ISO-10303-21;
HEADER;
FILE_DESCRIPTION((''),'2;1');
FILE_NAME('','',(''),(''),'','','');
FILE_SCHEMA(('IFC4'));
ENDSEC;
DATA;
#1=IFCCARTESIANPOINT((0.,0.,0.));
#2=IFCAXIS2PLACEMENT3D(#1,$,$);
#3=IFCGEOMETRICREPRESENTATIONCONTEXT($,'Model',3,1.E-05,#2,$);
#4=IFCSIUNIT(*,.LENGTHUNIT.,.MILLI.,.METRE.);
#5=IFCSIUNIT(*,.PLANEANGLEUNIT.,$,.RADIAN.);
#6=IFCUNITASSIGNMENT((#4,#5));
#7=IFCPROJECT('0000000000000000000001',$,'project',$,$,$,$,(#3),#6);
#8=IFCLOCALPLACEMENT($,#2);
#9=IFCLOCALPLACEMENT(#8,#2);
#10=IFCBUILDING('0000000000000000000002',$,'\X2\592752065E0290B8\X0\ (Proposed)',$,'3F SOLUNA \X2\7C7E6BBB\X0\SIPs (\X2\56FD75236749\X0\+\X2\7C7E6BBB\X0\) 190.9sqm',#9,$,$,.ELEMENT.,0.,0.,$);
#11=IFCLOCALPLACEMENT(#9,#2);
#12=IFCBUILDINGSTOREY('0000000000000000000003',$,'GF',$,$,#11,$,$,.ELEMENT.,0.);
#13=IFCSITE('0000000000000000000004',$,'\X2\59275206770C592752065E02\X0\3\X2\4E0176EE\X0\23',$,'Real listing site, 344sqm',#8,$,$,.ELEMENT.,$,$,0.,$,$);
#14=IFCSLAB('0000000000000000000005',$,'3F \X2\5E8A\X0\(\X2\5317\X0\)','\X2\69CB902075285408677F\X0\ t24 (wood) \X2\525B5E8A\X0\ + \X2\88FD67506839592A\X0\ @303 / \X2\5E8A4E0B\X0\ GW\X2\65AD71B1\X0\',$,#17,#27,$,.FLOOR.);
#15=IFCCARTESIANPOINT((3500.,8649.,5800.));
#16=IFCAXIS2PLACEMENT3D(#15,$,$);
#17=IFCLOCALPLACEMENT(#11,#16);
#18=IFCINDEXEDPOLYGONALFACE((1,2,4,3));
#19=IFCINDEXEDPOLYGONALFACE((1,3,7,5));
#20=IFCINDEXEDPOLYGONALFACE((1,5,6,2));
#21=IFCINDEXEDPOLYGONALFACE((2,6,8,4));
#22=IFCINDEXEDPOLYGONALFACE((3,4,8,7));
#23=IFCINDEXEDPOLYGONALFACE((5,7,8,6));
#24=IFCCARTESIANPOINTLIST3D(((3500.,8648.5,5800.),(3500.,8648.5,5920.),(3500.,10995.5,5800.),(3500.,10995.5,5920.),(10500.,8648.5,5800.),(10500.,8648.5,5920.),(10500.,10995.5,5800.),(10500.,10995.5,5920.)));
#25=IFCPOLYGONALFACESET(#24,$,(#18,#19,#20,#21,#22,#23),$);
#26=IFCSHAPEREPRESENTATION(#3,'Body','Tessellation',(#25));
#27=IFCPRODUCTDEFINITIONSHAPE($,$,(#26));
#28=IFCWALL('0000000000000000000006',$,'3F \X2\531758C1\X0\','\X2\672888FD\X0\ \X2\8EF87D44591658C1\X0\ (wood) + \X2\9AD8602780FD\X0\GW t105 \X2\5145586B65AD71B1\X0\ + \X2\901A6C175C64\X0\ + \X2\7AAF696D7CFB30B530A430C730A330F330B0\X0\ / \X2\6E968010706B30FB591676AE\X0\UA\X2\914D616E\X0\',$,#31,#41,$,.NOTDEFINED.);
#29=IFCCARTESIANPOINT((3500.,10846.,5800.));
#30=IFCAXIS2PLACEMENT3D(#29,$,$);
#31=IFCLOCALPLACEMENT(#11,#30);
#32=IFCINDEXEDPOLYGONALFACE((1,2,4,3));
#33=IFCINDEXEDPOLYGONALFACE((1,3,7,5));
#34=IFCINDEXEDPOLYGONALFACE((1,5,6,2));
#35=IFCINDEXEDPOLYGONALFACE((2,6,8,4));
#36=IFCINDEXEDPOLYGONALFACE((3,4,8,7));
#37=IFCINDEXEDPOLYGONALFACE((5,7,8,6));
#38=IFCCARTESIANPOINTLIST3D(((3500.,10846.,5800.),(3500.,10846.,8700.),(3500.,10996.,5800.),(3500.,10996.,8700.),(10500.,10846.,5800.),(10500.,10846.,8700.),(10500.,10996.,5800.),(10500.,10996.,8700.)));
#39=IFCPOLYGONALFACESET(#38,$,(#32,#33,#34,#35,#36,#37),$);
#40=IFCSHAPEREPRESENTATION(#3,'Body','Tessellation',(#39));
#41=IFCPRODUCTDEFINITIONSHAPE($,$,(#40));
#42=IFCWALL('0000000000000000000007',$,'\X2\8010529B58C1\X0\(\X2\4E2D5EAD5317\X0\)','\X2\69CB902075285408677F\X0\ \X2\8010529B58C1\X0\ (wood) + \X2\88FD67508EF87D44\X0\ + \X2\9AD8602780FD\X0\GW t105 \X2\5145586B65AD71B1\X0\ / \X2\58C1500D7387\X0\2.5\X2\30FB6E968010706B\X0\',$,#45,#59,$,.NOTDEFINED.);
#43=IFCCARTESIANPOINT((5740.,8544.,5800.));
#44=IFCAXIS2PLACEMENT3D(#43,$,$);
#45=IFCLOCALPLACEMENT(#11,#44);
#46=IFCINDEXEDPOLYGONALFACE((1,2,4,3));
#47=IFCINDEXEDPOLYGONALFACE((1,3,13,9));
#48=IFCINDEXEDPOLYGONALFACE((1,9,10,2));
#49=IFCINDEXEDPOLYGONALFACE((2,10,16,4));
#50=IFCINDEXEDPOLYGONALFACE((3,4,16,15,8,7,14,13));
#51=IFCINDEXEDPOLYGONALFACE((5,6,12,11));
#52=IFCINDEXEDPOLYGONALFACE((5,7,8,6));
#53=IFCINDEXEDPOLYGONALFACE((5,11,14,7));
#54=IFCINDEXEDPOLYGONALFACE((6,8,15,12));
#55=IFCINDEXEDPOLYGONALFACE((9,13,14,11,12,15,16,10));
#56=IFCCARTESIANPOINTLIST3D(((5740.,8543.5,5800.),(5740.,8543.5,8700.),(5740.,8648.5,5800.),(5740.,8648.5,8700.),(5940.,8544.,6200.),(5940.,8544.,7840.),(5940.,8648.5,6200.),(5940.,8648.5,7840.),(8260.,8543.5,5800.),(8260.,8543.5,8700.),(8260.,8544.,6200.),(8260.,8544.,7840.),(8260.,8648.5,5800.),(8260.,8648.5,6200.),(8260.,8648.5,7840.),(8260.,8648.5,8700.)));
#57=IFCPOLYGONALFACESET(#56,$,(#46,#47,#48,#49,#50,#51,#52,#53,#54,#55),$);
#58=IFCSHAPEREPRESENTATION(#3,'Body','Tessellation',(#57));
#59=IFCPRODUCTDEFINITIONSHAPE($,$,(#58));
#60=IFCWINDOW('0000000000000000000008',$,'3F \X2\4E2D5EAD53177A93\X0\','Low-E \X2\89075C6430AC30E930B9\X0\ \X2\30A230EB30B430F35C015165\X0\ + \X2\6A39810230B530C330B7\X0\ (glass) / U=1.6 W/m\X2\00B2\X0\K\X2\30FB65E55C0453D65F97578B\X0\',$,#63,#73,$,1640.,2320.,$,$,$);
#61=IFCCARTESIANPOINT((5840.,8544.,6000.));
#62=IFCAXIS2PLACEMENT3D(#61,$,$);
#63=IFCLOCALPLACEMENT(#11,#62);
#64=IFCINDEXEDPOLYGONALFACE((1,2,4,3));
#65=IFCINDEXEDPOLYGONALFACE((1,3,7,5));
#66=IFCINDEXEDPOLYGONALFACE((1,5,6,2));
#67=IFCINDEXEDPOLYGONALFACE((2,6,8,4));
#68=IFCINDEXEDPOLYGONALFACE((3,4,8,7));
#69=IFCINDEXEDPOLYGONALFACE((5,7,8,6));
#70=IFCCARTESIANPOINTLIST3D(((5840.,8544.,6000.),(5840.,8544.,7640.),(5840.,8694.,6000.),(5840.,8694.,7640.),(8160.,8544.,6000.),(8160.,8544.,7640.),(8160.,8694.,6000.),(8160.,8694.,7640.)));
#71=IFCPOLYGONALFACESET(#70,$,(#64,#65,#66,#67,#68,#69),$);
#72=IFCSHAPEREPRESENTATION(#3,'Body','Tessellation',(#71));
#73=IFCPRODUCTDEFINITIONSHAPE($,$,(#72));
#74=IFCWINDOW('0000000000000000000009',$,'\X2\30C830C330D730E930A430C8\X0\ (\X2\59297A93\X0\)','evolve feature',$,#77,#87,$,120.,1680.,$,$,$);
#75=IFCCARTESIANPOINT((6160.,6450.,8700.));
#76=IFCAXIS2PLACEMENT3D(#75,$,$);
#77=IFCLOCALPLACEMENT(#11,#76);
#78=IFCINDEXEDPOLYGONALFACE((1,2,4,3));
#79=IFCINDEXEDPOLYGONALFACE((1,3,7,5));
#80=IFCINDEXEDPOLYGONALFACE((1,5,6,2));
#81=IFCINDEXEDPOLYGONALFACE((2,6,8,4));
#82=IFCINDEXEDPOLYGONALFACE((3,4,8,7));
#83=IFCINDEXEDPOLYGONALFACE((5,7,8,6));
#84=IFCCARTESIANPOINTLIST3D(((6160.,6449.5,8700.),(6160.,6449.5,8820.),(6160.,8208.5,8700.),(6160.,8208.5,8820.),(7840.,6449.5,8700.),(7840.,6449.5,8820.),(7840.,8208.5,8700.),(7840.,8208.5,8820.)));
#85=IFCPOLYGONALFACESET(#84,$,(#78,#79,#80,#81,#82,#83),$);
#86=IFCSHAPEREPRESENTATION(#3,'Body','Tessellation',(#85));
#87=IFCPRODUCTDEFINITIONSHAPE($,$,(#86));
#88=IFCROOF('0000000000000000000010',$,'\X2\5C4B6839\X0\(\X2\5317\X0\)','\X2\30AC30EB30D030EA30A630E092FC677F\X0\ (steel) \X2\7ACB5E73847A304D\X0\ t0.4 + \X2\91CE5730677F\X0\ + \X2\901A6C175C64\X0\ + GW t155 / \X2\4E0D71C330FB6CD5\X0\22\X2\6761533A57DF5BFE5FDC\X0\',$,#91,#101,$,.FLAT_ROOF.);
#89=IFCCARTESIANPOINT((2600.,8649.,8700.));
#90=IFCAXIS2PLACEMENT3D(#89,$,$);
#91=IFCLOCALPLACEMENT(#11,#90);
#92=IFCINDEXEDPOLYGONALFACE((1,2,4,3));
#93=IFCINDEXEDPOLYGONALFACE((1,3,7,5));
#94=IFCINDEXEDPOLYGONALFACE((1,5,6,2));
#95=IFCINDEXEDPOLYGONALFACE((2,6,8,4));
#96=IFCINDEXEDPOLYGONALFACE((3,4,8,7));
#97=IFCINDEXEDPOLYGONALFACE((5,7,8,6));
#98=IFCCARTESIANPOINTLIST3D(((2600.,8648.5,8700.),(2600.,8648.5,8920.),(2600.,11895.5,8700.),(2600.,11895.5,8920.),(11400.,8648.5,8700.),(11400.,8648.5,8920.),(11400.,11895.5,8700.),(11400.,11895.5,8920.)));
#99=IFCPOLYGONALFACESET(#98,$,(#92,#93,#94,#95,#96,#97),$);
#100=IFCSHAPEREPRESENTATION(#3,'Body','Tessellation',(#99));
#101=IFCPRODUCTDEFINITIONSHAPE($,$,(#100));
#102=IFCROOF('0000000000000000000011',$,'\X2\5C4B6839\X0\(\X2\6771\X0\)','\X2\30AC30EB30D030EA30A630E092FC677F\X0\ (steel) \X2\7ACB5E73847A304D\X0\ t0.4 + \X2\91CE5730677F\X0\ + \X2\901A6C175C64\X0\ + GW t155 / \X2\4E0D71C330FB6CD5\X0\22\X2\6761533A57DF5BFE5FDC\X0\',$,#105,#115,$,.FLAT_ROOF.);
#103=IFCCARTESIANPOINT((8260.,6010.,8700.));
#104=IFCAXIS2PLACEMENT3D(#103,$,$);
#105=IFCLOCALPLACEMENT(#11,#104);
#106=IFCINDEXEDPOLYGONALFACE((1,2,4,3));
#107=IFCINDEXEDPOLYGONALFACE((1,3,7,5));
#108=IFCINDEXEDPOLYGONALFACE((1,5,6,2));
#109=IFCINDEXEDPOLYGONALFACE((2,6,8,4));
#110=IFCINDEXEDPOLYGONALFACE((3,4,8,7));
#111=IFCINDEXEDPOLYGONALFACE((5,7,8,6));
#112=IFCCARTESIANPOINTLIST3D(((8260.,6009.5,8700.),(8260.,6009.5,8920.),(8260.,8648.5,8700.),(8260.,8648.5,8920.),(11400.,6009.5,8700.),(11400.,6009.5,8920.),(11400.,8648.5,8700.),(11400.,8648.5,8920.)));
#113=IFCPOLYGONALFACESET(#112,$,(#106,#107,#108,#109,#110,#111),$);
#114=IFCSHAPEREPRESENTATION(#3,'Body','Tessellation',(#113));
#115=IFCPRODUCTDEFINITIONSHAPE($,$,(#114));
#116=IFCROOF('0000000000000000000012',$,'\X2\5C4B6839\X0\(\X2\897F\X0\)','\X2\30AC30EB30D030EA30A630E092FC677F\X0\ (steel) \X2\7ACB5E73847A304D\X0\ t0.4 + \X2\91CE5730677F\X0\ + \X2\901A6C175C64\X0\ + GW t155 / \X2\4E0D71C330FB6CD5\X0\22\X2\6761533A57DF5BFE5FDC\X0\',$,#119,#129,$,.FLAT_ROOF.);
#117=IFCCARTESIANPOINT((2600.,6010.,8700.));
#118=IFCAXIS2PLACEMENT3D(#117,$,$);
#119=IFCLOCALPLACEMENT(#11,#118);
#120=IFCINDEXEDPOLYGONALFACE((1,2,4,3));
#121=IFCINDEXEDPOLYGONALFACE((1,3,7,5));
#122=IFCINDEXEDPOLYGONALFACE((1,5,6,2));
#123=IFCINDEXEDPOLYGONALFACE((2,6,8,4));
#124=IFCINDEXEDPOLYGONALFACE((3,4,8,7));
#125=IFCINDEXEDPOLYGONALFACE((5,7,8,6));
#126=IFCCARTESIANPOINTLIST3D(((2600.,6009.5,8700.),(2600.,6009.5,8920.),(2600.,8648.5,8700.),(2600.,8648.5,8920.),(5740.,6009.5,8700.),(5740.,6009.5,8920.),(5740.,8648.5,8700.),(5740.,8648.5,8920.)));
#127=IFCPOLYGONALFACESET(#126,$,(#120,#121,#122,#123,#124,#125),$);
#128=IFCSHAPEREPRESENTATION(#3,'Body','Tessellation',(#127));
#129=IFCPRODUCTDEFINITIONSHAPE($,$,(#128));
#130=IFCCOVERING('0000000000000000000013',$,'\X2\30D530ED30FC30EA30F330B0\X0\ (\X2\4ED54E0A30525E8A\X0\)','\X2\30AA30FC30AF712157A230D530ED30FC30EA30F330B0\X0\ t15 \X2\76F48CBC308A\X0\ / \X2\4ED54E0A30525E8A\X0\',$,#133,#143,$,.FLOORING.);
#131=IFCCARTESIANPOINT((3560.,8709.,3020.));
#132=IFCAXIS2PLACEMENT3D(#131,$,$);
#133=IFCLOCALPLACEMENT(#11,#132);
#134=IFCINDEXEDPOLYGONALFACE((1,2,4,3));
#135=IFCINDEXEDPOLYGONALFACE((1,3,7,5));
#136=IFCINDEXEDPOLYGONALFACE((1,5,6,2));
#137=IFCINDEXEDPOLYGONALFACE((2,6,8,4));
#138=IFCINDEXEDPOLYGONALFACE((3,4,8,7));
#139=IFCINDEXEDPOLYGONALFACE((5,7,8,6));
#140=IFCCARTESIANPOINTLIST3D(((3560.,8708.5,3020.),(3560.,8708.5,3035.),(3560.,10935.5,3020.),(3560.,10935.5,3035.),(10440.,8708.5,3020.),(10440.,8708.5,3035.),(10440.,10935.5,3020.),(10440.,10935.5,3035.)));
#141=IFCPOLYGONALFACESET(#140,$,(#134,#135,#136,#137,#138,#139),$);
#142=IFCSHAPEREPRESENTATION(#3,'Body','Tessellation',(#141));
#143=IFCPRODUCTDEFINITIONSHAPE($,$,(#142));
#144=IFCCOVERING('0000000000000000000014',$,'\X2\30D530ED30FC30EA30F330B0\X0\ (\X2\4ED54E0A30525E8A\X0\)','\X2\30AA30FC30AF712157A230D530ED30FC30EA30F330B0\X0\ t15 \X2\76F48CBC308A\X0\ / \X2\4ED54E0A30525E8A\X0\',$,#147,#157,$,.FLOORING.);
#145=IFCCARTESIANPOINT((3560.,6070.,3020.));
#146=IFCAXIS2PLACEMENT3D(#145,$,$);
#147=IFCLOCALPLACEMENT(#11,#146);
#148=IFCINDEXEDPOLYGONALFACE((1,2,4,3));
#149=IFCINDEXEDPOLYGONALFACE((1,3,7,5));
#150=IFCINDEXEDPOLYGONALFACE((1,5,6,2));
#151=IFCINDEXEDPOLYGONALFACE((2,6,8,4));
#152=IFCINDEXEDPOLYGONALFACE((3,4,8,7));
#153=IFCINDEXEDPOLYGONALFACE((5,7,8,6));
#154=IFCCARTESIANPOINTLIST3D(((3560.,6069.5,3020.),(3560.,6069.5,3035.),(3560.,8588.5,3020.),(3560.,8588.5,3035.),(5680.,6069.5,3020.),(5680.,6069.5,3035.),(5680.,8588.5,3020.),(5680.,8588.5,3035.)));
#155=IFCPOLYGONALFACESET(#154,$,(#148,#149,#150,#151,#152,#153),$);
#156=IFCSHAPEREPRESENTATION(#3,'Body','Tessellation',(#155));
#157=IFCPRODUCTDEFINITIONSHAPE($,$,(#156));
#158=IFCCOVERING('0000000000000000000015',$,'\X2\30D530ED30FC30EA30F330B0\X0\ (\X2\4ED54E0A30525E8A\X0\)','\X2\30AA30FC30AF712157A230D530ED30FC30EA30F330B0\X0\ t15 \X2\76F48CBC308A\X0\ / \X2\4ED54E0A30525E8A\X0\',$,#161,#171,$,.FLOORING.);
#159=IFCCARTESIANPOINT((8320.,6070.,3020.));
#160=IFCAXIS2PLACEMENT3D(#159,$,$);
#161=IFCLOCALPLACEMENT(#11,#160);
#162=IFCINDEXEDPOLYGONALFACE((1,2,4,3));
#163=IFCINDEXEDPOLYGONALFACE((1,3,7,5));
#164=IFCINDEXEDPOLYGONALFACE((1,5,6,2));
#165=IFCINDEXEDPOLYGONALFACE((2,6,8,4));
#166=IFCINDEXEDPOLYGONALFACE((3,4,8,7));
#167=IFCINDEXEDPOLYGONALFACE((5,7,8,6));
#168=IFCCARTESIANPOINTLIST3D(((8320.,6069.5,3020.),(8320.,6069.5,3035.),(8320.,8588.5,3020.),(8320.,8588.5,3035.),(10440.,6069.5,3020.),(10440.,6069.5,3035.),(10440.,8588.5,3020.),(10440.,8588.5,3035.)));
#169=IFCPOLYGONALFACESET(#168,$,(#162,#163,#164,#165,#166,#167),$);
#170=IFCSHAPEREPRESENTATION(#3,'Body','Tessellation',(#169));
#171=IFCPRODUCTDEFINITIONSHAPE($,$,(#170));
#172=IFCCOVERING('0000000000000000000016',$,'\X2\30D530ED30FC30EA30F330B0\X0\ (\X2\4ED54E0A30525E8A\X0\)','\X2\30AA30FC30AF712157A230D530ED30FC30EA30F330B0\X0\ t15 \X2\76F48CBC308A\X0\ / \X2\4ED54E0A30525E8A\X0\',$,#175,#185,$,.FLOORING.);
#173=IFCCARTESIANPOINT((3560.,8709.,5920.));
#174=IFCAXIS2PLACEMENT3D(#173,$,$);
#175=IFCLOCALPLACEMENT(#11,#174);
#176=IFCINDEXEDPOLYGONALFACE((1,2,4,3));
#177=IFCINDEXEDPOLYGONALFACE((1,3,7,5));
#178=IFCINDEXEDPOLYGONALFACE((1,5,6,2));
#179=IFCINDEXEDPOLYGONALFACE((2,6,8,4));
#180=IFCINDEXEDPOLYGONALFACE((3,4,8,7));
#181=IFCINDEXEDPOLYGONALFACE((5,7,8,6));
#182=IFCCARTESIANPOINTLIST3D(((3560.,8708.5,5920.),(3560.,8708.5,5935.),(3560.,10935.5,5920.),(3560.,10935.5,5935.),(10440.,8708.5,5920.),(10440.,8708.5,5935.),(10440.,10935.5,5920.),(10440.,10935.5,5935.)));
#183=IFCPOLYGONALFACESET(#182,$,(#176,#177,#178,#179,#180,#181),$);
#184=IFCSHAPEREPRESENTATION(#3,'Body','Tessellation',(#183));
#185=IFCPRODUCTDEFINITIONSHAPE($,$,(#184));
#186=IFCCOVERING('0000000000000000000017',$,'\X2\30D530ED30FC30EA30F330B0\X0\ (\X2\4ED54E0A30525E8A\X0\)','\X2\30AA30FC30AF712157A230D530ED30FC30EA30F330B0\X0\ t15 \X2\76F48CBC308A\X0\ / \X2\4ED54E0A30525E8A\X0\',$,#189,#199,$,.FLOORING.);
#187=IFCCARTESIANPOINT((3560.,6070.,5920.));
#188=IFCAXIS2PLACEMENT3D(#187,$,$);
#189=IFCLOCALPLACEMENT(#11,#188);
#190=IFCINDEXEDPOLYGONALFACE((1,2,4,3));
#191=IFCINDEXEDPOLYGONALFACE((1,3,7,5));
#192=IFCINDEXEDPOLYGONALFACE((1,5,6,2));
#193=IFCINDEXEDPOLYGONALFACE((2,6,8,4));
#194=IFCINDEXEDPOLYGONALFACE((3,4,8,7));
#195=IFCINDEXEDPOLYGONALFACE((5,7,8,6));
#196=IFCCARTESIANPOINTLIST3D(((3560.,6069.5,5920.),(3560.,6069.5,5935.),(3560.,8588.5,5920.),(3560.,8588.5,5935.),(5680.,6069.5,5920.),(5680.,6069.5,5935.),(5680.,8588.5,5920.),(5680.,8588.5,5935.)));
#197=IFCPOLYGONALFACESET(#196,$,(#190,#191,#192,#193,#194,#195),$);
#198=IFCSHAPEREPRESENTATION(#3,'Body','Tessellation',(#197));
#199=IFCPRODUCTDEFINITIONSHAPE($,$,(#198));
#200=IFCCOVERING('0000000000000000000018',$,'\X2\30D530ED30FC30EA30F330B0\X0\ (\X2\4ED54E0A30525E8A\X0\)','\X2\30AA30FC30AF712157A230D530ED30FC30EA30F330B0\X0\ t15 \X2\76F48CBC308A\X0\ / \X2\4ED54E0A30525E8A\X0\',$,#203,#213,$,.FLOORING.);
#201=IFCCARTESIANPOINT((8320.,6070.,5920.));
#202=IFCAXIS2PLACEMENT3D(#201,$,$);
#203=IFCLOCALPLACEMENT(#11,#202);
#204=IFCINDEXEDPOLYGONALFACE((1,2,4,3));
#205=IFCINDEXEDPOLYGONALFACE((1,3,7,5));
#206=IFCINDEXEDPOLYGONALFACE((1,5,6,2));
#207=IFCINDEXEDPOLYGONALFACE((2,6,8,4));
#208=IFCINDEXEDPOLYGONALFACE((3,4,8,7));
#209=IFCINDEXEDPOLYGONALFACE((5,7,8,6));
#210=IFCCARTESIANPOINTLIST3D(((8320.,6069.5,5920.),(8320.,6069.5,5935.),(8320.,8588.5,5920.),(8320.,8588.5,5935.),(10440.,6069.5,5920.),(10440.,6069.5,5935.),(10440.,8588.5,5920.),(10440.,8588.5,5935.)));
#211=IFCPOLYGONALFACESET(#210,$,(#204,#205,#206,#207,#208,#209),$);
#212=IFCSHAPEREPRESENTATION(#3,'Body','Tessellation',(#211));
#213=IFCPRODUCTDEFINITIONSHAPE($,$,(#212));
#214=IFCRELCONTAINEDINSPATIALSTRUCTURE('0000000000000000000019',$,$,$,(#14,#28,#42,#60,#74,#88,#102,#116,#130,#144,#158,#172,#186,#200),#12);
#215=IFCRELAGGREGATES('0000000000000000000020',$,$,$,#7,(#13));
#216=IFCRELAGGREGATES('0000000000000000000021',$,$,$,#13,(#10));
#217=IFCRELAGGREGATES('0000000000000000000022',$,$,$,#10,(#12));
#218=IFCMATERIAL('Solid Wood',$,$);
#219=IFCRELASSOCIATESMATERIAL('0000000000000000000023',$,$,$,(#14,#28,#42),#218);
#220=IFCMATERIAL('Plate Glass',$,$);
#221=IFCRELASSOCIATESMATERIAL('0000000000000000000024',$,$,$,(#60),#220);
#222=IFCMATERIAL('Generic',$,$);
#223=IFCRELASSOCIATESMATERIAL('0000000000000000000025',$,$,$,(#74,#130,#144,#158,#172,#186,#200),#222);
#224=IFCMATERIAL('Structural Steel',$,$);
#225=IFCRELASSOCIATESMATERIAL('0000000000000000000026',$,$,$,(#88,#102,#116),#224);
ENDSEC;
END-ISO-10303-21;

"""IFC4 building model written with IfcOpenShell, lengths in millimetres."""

from ifc_helpers import new_model, si_unit, frame, frame_2d, origin, place, context, project, spatial, rectangle, extrude, material, element, fill, save


model = new_model("IFC4")

# Units and contexts
model_context = context("Model", 3, precision=1e-05, world=origin())
ifc_project = project(units=[si_unit("LENGTHUNIT", "METRE", prefix="MILLI"), si_unit("PLANEANGLEUNIT", "RADIAN")], contexts=[model_context])

# Site, building, storey
site_placement = place(None, origin())
site = spatial("IfcSite", under=ifc_project, at=site_placement, Name="大分県大分市3丁目23", ObjectType="Real listing site, 344sqm", CompositionType="ELEMENT", RefElevation=0.0)
building_placement = place(site_placement, origin())
building = spatial("IfcBuilding", under=site, at=building_placement, Name="大分市邸 (Proposed)", ObjectType="3F SOLUNA 籾殻SIPs (国産杉+籾殻) 190.9sqm", CompositionType="ELEMENT", ElevationOfRefHeight=0.0, ElevationOfTerrain=0.0)
storey_placement = place(building_placement, origin())
storey = spatial("IfcBuildingStorey", under=building, at=storey_placement, Name="GF", CompositionType="ELEMENT", Elevation=0.0)

# Slab
ifc_material_1 = material(Name="Solid Wood")
slab_placement = place(storey_placement, frame((3500.0, 8649.0, 5800.0)))
element("IfcSlab", 1, at=slab_placement, inside=storey, material=ifc_material_1, Name="3F 床(北)", Description="構造用合板 t24 (wood) 剛床 + 製材根太 @303 / 床下 GW断熱", PredefinedType="FLOOR", context=model_context, shape_type="SweptSolid", body=[
    extrude(rectangle(XDim=7000.0, YDim=2347.0, at=frame_2d((3500.0, 1173.0))), frame((3500.0, 8649.0, 5800.0)), (0.0, 0.0, 1.0), 120.0),
])

# Wall
wall_1_placement = place(storey_placement, frame((3500.0, 10846.0, 5800.0)))
element("IfcWall", 2, at=wall_1_placement, inside=storey, material=ifc_material_1, Name="3F 北壁", Description="木製 軸組外壁 (wood) + 高性能GW t105 充填断熱 + 通気層 + 窯業系サイディング / 準耐火・外皮UA配慮", PredefinedType="NOTDEFINED", context=model_context, shape_type="SweptSolid", body=[
    extrude(rectangle(XDim=7000.0, YDim=150.0, at=frame_2d((3500.0, 75.0))), frame((3500.0, 10846.0, 5800.0)), (0.0, 0.0, 1.0), 2900.0),
])

# Wall, opening, window
wall_2_placement = place(storey_placement, frame((5740.0, 8544.0, 5800.0)))
wall_2 = element("IfcWall", 3, at=wall_2_placement, inside=storey, material=ifc_material_1, Name="耐力壁(中庭北)", Description="構造用合板 耐力壁 (wood) + 製材軸組 + 高性能GW t105 充填断熱 / 壁倍率2.5・準耐火", PredefinedType="NOTDEFINED", context=model_context, shape_type="SweptSolid", body=[
    extrude(rectangle(XDim=2520.0, YDim=105.0, at=frame_2d((1260.0, 52.0))), frame((5740.0, 8544.0, 5800.0)), (0.0, 0.0, 1.0), 2900.0),
])
opening_placement = place(storey_placement, frame((5840.0, 8544.0, 6000.0)))
opening = element("IfcOpeningElement", 4, at=opening_placement, cuts=wall_2, PredefinedType="NOTDEFINED", context=model_context, shape_type="SweptSolid", body=[
    extrude(rectangle(XDim=2320.0, YDim=150.0, at=frame_2d((1160.0, 75.0))), frame((5840.0, 8544.0, 6000.0)), (0.0, 0.0, 1.0), 1640.0),
])
ifc_material_2 = material(Name="Plate Glass")
window_1_placement = place(storey_placement, frame((5840.0, 8544.0, 6000.0)))
window_1 = element("IfcWindow", 5, at=window_1_placement, inside=storey, material=ifc_material_2, Name="3F 中庭北窓", Description="Low-E 複層ガラス アルゴン封入 + 樹脂サッシ (glass) / U=1.6 W/m²K・日射取得型", OverallHeight=1640.0, OverallWidth=2320.0, context=model_context, shape_type="SweptSolid", body=[
    extrude(rectangle(XDim=2320.0, YDim=150.0, at=frame_2d((1160.0, 75.0))), frame((5840.0, 8544.0, 6000.0)), (0.0, 0.0, 1.0), 1640.0),
])
fill(opening, window_1)

# Window
ifc_material_3 = material(Name="Generic")
window_2_placement = place(storey_placement, frame((6160.0, 6450.0, 8700.0)))
element("IfcWindow", 6, at=window_2_placement, inside=storey, material=ifc_material_3, Name="トップライト (天窓)", Description="evolve feature", OverallHeight=120.0, OverallWidth=1680.0, context=model_context, shape_type="SweptSolid", body=[
    extrude(rectangle(XDim=1680.0, YDim=1759.0, at=frame_2d((840.0, 879.0))), frame((6160.0, 6450.0, 8700.0)), (0.0, 0.0, 1.0), 120.0),
])

# Roofs
ifc_material_4 = material(Name="Structural Steel")
roof_1_placement = place(storey_placement, frame((2600.0, 8649.0, 8700.0)))
element("IfcRoof", 7, at=roof_1_placement, inside=storey, material=ifc_material_4, Name="屋根(北)", Description="ガルバリウム鋼板 (steel) 立平葺き t0.4 + 野地板 + 通気層 + GW t155 / 不燃・法22条区域対応", PredefinedType="FLAT_ROOF", context=model_context, shape_type="SweptSolid", body=[
    extrude(rectangle(XDim=8800.0, YDim=3247.0, at=frame_2d((4400.0, 1623.0))), frame((2600.0, 8649.0, 8700.0)), (0.0, 0.0, 1.0), 220.0),
])
roof_2_placement = place(storey_placement, frame((8260.0, 6010.0, 8700.0)))
element("IfcRoof", 8, at=roof_2_placement, inside=storey, material=ifc_material_4, Name="屋根(東)", Description="ガルバリウム鋼板 (steel) 立平葺き t0.4 + 野地板 + 通気層 + GW t155 / 不燃・法22条区域対応", PredefinedType="FLAT_ROOF", context=model_context, shape_type="SweptSolid", body=[
    extrude(rectangle(XDim=3140.0, YDim=2639.0, at=frame_2d((1570.0, 1319.0))), frame((8260.0, 6010.0, 8700.0)), (0.0, 0.0, 1.0), 220.0),
])
roof_3_placement = place(storey_placement, frame((2600.0, 6010.0, 8700.0)))
element("IfcRoof", 9, at=roof_3_placement, inside=storey, material=ifc_material_4, Name="屋根(西)", Description="ガルバリウム鋼板 (steel) 立平葺き t0.4 + 野地板 + 通気層 + GW t155 / 不燃・法22条区域対応", PredefinedType="FLAT_ROOF", context=model_context, shape_type="SweptSolid", body=[
    extrude(rectangle(XDim=3140.0, YDim=2639.0, at=frame_2d((1570.0, 1319.0))), frame((2600.0, 6010.0, 8700.0)), (0.0, 0.0, 1.0), 220.0),
])

# Coverings
covering_1_placement = place(storey_placement, frame((3560.0, 8709.0, 3020.0)))
element("IfcCovering", 10, at=covering_1_placement, inside=storey, material=ifc_material_3, Name="フローリング (仕上げ床)", Description="オーク無垢フローリング t15 直貼り / 仕上げ床", PredefinedType="FLOORING", context=model_context, shape_type="SweptSolid", body=[
    extrude(rectangle(XDim=6880.0, YDim=2227.0, at=frame_2d((3440.0, 1113.0))), frame((3560.0, 8709.0, 3020.0)), (0.0, 0.0, 1.0), 15.0),
])
covering_2_placement = place(storey_placement, frame((3560.0, 6070.0, 3020.0)))
element("IfcCovering", 11, at=covering_2_placement, inside=storey, material=ifc_material_3, Name="フローリング (仕上げ床)", Description="オーク無垢フローリング t15 直貼り / 仕上げ床", PredefinedType="FLOORING", context=model_context, shape_type="SweptSolid", body=[
    extrude(rectangle(XDim=2120.0, YDim=2519.0, at=frame_2d((1060.0, 1259.0))), frame((3560.0, 6070.0, 3020.0)), (0.0, 0.0, 1.0), 15.0),
])
covering_3_placement = place(storey_placement, frame((8320.0, 6070.0, 3020.0)))
element("IfcCovering", 12, at=covering_3_placement, inside=storey, material=ifc_material_3, Name="フローリング (仕上げ床)", Description="オーク無垢フローリング t15 直貼り / 仕上げ床", PredefinedType="FLOORING", context=model_context, shape_type="SweptSolid", body=[
    extrude(rectangle(XDim=2120.0, YDim=2519.0, at=frame_2d((1060.0, 1259.0))), frame((8320.0, 6070.0, 3020.0)), (0.0, 0.0, 1.0), 15.0),
])
covering_4_placement = place(storey_placement, frame((3560.0, 8709.0, 5920.0)))
element("IfcCovering", 13, at=covering_4_placement, inside=storey, material=ifc_material_3, Name="フローリング (仕上げ床)", Description="オーク無垢フローリング t15 直貼り / 仕上げ床", PredefinedType="FLOORING", context=model_context, shape_type="SweptSolid", body=[
    extrude(rectangle(XDim=6880.0, YDim=2227.0, at=frame_2d((3440.0, 1113.0))), frame((3560.0, 8709.0, 5920.0)), (0.0, 0.0, 1.0), 15.0),
])
covering_5_placement = place(storey_placement, frame((3560.0, 6070.0, 5920.0)))
element("IfcCovering", 14, at=covering_5_placement, inside=storey, material=ifc_material_3, Name="フローリング (仕上げ床)", Description="オーク無垢フローリング t15 直貼り / 仕上げ床", PredefinedType="FLOORING", context=model_context, shape_type="SweptSolid", body=[
    extrude(rectangle(XDim=2120.0, YDim=2519.0, at=frame_2d((1060.0, 1259.0))), frame((3560.0, 6070.0, 5920.0)), (0.0, 0.0, 1.0), 15.0),
])
covering_6_placement = place(storey_placement, frame((8320.0, 6070.0, 5920.0)))
element("IfcCovering", 15, at=covering_6_placement, inside=storey, material=ifc_material_3, Name="フローリング (仕上げ床)", Description="オーク無垢フローリング t15 直貼り / 仕上げ床", PredefinedType="FLOORING", context=model_context, shape_type="SweptSolid", body=[
    extrude(rectangle(XDim=2120.0, YDim=2519.0, at=frame_2d((1060.0, 1259.0))), frame((8320.0, 6070.0, 5920.0)), (0.0, 0.0, 1.0), 15.0),
])

save(model, "model.ifc")
